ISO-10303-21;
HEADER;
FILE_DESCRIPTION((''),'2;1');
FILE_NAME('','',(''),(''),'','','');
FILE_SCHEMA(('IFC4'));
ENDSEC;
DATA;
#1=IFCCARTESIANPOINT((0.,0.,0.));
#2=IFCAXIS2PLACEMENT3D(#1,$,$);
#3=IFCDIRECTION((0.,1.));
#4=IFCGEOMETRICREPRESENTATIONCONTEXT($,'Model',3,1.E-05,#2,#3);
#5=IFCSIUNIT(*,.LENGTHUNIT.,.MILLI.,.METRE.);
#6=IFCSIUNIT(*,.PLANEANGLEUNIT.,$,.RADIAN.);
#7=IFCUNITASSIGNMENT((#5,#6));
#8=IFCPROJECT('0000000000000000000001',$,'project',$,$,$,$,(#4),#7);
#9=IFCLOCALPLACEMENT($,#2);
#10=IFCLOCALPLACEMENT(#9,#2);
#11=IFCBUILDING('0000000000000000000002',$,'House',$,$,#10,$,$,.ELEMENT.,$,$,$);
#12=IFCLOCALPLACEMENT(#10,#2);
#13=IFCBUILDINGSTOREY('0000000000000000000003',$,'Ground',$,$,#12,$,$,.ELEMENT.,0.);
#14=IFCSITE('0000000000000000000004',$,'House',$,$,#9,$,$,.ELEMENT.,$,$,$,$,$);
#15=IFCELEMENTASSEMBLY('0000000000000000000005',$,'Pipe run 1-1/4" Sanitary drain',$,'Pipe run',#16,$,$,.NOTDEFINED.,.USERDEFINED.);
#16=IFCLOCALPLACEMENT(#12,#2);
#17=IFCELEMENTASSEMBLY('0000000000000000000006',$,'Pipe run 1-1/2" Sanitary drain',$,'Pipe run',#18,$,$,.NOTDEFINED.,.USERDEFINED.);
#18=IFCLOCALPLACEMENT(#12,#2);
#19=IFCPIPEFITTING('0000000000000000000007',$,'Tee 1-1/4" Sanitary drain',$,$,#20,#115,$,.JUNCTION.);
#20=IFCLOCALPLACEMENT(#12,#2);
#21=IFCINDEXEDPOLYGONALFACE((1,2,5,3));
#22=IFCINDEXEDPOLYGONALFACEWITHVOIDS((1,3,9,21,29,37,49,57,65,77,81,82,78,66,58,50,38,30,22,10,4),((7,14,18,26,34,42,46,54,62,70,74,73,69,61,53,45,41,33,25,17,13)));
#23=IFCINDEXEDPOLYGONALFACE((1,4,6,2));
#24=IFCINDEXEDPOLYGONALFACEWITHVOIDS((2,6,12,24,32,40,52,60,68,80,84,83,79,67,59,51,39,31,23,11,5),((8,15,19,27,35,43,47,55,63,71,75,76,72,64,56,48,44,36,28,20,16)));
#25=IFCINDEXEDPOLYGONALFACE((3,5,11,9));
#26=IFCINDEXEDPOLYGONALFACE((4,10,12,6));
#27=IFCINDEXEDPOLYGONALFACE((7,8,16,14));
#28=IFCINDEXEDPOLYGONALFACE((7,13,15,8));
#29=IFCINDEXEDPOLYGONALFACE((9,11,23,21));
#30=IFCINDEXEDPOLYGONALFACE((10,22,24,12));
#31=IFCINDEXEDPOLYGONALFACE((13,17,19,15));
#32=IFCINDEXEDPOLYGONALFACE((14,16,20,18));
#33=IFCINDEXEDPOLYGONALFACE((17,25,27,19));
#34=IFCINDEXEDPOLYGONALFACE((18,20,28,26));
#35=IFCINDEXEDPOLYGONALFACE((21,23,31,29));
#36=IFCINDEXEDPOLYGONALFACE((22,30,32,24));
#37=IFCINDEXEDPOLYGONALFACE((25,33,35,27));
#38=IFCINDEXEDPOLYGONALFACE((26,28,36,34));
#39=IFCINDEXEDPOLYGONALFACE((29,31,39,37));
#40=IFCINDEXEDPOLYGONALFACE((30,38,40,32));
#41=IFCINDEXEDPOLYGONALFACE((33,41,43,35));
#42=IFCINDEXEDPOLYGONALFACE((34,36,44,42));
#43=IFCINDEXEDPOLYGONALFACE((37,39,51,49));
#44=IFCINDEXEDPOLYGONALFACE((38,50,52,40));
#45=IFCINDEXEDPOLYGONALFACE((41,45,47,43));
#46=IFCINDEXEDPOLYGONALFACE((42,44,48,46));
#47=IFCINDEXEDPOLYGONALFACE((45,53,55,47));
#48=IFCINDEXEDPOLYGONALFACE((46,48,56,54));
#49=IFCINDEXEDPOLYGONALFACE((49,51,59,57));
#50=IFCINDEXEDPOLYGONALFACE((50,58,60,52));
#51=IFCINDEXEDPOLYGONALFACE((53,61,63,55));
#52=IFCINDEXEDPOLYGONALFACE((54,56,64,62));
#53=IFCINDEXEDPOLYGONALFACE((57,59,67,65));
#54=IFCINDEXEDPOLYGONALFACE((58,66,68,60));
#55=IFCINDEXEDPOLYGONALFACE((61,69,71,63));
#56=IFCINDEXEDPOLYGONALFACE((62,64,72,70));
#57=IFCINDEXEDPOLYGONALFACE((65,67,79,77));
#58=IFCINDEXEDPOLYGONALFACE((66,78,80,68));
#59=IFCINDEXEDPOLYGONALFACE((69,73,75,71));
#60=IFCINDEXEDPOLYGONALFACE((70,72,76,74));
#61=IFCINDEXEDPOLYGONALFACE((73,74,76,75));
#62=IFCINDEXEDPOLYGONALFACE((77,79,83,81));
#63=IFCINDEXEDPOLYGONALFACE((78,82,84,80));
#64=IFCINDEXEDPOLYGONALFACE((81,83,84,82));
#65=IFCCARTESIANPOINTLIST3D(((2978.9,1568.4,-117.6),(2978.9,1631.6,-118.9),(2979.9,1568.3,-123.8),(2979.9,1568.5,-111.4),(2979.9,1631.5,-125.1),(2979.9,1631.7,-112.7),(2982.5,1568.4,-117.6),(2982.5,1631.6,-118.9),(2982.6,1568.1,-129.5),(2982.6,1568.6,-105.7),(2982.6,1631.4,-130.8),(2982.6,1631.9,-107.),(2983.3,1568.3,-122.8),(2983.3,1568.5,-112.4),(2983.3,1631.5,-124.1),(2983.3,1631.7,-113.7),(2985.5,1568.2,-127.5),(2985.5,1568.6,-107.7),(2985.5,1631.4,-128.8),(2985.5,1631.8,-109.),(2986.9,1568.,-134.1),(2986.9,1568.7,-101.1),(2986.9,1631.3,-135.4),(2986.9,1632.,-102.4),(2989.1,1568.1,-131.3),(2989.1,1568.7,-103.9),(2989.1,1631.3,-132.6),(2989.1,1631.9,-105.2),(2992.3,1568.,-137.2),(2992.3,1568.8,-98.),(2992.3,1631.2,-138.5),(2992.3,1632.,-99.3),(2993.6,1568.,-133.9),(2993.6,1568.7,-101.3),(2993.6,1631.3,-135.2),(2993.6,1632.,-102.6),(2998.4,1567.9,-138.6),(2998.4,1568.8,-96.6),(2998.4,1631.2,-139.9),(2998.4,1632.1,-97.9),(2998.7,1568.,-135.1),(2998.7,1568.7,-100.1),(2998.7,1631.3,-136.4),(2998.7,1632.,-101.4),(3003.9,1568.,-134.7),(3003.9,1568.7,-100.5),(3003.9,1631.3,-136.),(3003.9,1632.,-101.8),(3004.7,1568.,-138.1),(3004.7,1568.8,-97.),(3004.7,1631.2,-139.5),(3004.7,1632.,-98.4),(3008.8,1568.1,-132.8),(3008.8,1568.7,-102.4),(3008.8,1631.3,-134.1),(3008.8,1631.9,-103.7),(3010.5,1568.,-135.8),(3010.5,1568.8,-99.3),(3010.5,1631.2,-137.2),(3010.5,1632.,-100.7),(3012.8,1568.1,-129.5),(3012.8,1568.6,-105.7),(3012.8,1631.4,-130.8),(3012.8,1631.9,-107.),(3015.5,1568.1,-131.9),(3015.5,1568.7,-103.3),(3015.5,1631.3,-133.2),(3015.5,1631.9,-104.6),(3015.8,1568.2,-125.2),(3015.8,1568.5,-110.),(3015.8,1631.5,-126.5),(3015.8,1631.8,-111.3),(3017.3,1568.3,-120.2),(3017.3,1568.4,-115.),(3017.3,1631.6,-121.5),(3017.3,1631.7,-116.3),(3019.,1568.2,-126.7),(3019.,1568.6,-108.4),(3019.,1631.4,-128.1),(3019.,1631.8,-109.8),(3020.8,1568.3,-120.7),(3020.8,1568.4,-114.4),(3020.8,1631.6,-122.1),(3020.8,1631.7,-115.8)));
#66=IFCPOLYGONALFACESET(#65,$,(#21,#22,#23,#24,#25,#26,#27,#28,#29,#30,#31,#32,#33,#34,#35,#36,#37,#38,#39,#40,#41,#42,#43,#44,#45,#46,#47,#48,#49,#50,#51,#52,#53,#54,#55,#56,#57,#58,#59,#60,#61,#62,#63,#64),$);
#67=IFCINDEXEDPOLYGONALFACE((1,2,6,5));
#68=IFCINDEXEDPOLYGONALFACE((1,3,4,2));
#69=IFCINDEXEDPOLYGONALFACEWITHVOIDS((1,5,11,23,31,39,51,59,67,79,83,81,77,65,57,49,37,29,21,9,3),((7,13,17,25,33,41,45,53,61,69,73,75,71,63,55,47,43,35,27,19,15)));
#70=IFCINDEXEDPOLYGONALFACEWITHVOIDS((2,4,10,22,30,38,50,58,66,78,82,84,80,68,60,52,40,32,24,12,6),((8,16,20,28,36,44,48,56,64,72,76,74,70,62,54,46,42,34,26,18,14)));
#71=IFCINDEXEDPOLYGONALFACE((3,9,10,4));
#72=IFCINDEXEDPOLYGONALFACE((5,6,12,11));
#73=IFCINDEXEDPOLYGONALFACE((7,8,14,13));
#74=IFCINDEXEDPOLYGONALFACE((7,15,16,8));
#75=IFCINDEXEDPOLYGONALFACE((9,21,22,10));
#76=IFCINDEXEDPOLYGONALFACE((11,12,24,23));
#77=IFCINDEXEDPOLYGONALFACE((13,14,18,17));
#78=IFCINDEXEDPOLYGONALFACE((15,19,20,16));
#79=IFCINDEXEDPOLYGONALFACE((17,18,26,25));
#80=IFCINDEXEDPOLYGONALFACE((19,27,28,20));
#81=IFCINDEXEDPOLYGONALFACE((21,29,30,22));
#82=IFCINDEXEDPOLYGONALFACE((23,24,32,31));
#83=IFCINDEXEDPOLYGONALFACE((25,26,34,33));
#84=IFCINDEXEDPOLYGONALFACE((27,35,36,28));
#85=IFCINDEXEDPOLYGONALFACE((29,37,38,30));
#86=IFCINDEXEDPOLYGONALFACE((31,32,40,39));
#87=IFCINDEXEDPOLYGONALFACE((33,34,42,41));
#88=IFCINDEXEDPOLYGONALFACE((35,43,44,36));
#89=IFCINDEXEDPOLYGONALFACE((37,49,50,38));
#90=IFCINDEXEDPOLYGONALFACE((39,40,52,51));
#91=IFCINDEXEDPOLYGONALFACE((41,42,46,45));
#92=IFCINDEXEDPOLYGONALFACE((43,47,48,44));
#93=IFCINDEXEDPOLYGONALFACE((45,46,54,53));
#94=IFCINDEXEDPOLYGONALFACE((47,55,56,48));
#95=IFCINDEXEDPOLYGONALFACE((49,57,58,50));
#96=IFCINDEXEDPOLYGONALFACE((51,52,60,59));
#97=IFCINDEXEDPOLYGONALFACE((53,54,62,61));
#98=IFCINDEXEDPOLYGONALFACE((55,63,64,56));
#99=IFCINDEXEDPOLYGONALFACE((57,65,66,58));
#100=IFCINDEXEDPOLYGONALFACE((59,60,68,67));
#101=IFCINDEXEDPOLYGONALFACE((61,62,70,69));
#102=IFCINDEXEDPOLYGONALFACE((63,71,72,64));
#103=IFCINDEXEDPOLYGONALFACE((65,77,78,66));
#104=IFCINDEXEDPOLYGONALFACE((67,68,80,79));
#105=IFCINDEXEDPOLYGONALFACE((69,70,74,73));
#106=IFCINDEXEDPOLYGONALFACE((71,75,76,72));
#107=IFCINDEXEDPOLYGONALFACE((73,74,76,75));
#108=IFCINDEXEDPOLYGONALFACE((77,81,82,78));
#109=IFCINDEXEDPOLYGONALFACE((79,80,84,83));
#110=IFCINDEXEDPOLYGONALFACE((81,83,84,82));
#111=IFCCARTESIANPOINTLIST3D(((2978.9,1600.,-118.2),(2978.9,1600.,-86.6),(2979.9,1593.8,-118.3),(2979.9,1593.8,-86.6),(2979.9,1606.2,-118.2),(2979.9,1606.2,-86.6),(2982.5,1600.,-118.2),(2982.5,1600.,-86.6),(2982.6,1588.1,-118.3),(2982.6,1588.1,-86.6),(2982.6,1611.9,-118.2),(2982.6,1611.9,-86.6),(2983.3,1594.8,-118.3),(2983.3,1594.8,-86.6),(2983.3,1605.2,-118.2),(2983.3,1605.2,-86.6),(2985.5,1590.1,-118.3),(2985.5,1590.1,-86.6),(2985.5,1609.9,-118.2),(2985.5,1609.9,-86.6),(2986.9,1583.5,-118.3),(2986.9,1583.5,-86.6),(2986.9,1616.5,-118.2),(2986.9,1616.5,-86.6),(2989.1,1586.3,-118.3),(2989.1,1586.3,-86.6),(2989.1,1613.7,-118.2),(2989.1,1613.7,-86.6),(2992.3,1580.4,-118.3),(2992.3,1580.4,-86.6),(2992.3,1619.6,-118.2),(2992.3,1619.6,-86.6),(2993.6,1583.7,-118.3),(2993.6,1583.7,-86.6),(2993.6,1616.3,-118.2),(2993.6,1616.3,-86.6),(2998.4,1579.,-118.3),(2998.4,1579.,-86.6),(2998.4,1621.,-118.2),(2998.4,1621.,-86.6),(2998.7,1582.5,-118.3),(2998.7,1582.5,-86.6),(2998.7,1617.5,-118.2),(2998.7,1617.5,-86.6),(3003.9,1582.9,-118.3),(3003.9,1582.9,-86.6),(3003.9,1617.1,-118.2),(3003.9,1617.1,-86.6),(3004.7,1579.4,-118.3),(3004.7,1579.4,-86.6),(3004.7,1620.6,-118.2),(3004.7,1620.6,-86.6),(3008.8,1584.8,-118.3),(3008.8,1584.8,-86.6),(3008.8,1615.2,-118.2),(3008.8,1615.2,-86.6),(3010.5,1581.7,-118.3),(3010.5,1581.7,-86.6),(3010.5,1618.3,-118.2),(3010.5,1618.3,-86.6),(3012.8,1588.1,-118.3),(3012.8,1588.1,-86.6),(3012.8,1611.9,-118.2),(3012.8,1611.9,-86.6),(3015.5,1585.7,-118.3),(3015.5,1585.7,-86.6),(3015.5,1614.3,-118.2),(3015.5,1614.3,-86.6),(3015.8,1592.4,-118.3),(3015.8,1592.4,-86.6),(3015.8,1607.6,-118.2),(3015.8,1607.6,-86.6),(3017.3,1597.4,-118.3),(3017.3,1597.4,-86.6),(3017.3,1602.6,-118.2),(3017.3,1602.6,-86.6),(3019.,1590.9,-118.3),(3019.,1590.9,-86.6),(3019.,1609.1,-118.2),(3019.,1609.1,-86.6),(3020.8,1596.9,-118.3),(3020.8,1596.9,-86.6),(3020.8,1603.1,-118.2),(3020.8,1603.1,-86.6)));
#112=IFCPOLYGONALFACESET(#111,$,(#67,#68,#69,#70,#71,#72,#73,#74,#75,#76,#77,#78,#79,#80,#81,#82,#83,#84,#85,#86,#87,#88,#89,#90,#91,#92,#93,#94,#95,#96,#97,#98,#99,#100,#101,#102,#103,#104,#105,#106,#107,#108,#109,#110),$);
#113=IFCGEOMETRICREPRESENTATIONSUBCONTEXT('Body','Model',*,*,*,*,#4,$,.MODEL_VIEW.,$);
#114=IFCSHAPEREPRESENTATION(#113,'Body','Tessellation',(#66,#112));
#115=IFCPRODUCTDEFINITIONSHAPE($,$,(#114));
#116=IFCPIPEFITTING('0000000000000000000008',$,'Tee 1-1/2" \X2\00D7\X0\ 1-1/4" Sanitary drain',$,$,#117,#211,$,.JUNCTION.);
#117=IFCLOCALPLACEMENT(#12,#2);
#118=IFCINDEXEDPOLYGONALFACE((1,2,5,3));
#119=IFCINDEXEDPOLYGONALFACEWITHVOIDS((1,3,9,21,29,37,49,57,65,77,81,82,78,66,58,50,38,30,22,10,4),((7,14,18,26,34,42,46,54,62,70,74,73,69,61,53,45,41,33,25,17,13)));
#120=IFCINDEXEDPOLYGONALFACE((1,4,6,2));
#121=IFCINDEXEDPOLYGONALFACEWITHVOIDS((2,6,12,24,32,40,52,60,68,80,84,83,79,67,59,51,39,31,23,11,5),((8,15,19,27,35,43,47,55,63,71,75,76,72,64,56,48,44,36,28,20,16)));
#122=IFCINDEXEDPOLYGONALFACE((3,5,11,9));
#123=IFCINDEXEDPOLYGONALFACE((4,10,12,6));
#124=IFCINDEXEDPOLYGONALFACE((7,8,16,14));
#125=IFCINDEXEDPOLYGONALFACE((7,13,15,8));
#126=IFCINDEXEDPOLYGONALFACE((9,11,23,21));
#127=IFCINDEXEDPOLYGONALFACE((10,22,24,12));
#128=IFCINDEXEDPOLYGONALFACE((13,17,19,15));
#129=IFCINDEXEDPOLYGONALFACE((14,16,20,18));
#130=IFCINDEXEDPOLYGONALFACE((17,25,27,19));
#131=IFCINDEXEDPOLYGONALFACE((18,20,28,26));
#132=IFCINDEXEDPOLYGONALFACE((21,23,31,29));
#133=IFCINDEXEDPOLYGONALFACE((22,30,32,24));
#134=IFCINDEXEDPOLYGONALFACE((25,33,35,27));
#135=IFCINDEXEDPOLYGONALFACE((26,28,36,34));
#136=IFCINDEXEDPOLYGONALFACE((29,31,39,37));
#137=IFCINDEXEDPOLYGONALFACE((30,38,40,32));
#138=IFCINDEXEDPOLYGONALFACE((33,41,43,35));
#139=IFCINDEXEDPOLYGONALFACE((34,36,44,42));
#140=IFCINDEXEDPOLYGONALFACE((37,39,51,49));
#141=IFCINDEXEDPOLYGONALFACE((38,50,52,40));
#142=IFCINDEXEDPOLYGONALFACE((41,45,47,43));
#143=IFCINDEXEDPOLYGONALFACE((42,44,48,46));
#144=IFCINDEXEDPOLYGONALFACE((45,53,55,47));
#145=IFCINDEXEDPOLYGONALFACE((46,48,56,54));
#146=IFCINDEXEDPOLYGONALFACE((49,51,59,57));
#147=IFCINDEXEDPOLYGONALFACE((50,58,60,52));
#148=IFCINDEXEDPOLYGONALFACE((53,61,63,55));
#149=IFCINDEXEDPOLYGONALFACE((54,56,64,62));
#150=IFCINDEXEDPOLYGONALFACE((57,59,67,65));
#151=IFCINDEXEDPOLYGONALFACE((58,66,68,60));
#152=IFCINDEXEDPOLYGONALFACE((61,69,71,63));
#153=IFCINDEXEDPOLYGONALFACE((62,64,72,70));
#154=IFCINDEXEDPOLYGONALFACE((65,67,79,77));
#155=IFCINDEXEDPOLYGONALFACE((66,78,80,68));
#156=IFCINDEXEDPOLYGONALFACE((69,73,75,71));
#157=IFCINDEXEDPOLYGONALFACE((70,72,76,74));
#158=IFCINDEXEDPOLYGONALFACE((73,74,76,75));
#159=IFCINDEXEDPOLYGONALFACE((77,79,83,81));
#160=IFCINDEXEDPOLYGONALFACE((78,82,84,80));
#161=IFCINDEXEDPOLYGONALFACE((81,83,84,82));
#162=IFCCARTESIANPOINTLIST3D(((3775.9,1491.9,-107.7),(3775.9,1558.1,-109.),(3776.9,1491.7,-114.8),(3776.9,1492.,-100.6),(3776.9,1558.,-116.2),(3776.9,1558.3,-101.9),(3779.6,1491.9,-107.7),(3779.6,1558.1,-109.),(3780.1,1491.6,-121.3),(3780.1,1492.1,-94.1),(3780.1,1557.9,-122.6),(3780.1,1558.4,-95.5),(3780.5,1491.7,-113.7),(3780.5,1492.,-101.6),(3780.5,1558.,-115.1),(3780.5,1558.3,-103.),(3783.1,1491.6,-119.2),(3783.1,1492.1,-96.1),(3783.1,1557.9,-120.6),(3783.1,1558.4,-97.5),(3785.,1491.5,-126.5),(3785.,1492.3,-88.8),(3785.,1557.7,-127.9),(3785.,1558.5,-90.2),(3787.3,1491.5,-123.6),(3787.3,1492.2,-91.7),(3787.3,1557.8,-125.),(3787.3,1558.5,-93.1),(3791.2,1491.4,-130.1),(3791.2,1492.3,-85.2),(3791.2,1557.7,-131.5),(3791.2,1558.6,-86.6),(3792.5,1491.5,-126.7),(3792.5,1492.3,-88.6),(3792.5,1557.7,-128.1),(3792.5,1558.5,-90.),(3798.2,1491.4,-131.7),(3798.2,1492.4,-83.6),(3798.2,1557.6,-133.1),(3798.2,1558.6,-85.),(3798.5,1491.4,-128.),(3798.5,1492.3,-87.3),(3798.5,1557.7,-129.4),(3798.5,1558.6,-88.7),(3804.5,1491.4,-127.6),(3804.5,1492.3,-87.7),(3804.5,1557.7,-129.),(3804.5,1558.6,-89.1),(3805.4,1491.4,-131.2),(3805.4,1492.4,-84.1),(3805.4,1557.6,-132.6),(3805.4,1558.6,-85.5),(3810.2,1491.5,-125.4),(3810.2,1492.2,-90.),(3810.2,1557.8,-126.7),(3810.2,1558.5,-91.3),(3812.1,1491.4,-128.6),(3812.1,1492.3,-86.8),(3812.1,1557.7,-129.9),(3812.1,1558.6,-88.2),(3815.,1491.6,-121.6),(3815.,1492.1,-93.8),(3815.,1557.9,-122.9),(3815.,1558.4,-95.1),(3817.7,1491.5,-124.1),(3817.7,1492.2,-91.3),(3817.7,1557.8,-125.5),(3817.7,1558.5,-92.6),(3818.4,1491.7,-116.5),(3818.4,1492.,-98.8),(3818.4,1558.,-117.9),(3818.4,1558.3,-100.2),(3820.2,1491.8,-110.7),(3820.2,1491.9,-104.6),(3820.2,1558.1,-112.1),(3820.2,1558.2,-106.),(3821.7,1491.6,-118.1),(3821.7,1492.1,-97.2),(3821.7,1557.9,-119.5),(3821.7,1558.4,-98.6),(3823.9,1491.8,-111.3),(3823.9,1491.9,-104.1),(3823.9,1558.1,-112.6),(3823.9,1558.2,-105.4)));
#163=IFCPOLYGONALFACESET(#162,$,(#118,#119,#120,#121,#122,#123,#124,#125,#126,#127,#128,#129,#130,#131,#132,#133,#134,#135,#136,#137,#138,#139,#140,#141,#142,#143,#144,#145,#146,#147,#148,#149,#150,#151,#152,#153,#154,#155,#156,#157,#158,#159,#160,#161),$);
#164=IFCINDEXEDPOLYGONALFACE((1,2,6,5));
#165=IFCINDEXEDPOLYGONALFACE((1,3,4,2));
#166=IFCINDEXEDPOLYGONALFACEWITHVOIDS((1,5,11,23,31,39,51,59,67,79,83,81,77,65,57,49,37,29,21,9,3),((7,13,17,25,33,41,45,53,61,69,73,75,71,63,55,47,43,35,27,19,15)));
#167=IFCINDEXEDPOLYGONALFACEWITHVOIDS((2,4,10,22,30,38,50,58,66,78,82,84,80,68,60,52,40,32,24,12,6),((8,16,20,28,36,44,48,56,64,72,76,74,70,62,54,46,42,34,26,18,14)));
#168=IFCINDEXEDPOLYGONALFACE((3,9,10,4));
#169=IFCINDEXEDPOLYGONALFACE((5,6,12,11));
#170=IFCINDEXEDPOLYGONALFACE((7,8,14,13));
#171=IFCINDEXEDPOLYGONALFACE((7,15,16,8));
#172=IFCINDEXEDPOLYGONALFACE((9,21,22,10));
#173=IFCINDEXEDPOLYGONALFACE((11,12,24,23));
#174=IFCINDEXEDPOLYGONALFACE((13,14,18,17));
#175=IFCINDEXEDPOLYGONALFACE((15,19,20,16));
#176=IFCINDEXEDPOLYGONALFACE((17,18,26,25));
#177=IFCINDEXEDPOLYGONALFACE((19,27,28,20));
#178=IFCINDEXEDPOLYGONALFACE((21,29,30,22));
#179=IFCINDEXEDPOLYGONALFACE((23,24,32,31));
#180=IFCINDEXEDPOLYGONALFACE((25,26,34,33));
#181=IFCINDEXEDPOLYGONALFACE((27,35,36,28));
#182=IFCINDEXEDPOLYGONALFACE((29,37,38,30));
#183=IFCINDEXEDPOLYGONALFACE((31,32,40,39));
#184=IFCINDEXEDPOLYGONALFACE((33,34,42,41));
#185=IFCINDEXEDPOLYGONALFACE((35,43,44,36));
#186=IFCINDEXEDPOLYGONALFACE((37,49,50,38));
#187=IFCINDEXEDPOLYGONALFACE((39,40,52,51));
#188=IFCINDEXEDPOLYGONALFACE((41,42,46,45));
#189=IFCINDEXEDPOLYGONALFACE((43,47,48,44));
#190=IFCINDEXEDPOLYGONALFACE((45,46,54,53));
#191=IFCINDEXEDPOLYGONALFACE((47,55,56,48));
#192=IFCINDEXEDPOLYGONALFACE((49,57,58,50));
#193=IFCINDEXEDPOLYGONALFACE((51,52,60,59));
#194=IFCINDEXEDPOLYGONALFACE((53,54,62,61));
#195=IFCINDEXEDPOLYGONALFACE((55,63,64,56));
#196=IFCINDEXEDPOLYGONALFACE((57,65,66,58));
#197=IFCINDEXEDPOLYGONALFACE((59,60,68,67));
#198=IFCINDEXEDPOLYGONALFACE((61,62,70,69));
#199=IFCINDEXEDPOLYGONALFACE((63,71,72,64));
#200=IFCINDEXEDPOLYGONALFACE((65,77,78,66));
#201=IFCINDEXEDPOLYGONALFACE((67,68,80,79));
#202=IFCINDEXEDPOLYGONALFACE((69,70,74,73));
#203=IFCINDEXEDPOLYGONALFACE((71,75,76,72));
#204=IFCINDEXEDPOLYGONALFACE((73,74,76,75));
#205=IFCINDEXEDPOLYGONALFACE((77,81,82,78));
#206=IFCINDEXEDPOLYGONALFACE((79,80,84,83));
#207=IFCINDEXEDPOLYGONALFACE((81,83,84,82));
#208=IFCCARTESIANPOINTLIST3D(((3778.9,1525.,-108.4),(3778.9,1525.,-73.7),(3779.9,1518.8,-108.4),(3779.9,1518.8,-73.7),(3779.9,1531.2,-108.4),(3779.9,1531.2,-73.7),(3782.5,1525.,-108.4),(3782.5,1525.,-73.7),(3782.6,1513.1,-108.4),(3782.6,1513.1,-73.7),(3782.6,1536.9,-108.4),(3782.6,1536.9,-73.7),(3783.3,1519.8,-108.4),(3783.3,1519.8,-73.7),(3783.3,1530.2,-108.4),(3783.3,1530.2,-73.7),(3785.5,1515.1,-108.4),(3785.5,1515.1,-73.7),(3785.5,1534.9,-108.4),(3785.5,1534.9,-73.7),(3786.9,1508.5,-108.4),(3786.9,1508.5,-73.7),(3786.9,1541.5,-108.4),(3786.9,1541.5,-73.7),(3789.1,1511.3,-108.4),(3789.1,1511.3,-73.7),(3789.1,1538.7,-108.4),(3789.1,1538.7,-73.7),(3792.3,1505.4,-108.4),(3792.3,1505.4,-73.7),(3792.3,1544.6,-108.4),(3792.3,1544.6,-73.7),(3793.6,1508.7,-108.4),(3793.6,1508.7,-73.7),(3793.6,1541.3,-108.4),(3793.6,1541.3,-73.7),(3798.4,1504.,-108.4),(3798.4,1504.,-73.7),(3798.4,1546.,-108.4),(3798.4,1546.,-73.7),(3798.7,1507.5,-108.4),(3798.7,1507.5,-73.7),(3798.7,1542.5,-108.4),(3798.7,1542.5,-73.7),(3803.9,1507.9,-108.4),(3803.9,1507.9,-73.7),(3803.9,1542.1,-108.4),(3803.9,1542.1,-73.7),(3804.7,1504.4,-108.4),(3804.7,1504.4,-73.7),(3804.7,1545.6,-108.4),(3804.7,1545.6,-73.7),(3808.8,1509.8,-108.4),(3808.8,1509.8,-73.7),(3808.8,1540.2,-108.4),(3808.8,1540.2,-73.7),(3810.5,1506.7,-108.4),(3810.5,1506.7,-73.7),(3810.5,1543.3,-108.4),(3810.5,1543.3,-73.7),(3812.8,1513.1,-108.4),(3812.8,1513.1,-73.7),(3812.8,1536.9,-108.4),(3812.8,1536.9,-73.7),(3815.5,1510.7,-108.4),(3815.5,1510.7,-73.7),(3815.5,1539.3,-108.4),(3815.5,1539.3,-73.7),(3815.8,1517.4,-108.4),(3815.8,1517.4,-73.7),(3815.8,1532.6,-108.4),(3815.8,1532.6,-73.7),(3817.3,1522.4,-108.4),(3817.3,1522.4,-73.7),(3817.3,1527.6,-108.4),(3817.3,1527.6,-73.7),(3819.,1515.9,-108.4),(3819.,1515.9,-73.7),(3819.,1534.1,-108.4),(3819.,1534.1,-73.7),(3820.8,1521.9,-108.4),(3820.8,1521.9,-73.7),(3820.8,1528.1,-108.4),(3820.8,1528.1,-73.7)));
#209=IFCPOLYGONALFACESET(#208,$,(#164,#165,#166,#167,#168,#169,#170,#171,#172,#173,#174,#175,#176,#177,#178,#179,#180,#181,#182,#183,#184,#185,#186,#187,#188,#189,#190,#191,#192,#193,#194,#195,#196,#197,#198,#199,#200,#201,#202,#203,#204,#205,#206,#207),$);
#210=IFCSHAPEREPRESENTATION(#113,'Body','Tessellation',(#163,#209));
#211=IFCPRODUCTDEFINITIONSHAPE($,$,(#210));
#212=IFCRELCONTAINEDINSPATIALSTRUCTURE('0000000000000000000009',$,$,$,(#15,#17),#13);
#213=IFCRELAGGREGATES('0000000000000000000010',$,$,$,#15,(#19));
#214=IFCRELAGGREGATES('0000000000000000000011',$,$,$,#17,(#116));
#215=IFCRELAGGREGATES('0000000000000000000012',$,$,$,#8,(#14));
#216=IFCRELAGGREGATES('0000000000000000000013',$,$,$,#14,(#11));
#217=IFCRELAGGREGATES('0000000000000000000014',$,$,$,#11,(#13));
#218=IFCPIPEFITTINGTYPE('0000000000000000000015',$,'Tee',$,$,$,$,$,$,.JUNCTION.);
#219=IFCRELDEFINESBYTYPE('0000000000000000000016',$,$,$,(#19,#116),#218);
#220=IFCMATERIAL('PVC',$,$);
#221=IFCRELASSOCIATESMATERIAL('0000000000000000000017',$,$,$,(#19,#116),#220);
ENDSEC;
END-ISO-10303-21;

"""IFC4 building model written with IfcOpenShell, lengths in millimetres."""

from ifc_helpers import new_model, si_unit, direction, frame, origin, origin_with_axes, origin_2d, place, context, subcontext, project, spatial, hollow_circle, extrude, material, type_object, element, aggregate, save


model = new_model("IFC4")

# Units and contexts
model_context = context("Model", 3, precision=1e-05, world=origin(), true_north=direction((0.0, 1.0)))
body_context = subcontext(model_context, "Body", "Model", "MODEL_VIEW")
ifc_project = project(units=[si_unit("LENGTHUNIT", "METRE", prefix="MILLI"), si_unit("PLANEANGLEUNIT", "RADIAN")], contexts=[model_context])

# Site, building, storey
site_placement = place(None, origin())
site = spatial("IfcSite", under=ifc_project, at=site_placement, Name="House", CompositionType="ELEMENT")
building_placement = place(site_placement, origin())
building = spatial("IfcBuilding", under=site, at=building_placement, Name="House", CompositionType="ELEMENT")
storey_placement = place(building_placement, origin())
storey = spatial("IfcBuildingStorey", under=building, at=storey_placement, Name="Ground", CompositionType="ELEMENT", Elevation=0.0)

# Shared definitions
ifc_material = material(Name="PVC")

# Element assembly
assembly_1_placement = place(storey_placement, origin_with_axes())
assembly_1 = element("IfcElementAssembly", 1, at=assembly_1_placement, inside=storey, Name="Pipe run 1-1/4\" Sanitary drain", ObjectType="Pipe run", AssemblyPlace="NOTDEFINED", PredefinedType="USERDEFINED")

# Element assembly
assembly_2_placement = place(storey_placement, origin_with_axes())
assembly_2 = element("IfcElementAssembly", 2, at=assembly_2_placement, inside=storey, Name="Pipe run 1-1/2\" Sanitary drain", ObjectType="Pipe run", AssemblyPlace="NOTDEFINED", PredefinedType="USERDEFINED")

# Pipe fittings
pipe_fitting_type_1 = type_object("IfcPipeFittingType", Name="Tee", PredefinedType="JUNCTION")
pipe_fitting_1_placement = place(storey_placement, origin_with_axes())
pipe_fitting_1 = element("IfcPipeFitting", 3, at=pipe_fitting_1_placement, type_object=pipe_fitting_type_1, material=ifc_material, Name="Tee 1-1/4\" Sanitary drain", PredefinedType="JUNCTION", context=body_context, shape_type="SweptSolid", body=[
    extrude(hollow_circle(Radius=21.1, WallThickness=3.6, at=origin_2d()), frame((3000.0, 1568.4, -117.6), z_axis=(0.0, 0.999783, -0.020829), x_axis=(-1.0, 0.0, 0.0)), (0.0, 0.0, 1.0), 63.2),
    extrude(hollow_circle(Radius=21.1, WallThickness=3.6, at=origin_2d()), frame((3000.0, 1600.0, -118.2), z_axis=(0.0, 0.0, 1.0), x_axis=(-1.0, 0.0, 0.0)), (0.0, 0.0, 1.0), 31.6),
])
aggregate(assembly_1, [pipe_fitting_1])
pipe_fitting_2_placement = place(storey_placement, origin_with_axes())
pipe_fitting_2 = element("IfcPipeFitting", 4, at=pipe_fitting_2_placement, type_object=pipe_fitting_type_1, material=ifc_material, Name="Tee 1-1/2\" × 1-1/4\" Sanitary drain", PredefinedType="JUNCTION", context=body_context, shape_type="SweptSolid", body=[
    extrude(hollow_circle(Radius=24.1, WallThickness=3.7, at=origin_2d()), frame((3800.0, 1491.9, -107.7), z_axis=(0.0, 0.999783, -0.020829), x_axis=(-1.0, 0.0, 0.0)), (0.0, 0.0, 1.0), 66.3),
    extrude(hollow_circle(Radius=21.1, WallThickness=3.6, at=origin_2d()), frame((3800.0, 1525.0, -108.4), z_axis=(0.0, 0.0, 1.0), x_axis=(-1.0, 0.0, 0.0)), (0.0, 0.0, 1.0), 34.7),
])
aggregate(assembly_2, [pipe_fitting_2])

save(model, "model.ifc")
